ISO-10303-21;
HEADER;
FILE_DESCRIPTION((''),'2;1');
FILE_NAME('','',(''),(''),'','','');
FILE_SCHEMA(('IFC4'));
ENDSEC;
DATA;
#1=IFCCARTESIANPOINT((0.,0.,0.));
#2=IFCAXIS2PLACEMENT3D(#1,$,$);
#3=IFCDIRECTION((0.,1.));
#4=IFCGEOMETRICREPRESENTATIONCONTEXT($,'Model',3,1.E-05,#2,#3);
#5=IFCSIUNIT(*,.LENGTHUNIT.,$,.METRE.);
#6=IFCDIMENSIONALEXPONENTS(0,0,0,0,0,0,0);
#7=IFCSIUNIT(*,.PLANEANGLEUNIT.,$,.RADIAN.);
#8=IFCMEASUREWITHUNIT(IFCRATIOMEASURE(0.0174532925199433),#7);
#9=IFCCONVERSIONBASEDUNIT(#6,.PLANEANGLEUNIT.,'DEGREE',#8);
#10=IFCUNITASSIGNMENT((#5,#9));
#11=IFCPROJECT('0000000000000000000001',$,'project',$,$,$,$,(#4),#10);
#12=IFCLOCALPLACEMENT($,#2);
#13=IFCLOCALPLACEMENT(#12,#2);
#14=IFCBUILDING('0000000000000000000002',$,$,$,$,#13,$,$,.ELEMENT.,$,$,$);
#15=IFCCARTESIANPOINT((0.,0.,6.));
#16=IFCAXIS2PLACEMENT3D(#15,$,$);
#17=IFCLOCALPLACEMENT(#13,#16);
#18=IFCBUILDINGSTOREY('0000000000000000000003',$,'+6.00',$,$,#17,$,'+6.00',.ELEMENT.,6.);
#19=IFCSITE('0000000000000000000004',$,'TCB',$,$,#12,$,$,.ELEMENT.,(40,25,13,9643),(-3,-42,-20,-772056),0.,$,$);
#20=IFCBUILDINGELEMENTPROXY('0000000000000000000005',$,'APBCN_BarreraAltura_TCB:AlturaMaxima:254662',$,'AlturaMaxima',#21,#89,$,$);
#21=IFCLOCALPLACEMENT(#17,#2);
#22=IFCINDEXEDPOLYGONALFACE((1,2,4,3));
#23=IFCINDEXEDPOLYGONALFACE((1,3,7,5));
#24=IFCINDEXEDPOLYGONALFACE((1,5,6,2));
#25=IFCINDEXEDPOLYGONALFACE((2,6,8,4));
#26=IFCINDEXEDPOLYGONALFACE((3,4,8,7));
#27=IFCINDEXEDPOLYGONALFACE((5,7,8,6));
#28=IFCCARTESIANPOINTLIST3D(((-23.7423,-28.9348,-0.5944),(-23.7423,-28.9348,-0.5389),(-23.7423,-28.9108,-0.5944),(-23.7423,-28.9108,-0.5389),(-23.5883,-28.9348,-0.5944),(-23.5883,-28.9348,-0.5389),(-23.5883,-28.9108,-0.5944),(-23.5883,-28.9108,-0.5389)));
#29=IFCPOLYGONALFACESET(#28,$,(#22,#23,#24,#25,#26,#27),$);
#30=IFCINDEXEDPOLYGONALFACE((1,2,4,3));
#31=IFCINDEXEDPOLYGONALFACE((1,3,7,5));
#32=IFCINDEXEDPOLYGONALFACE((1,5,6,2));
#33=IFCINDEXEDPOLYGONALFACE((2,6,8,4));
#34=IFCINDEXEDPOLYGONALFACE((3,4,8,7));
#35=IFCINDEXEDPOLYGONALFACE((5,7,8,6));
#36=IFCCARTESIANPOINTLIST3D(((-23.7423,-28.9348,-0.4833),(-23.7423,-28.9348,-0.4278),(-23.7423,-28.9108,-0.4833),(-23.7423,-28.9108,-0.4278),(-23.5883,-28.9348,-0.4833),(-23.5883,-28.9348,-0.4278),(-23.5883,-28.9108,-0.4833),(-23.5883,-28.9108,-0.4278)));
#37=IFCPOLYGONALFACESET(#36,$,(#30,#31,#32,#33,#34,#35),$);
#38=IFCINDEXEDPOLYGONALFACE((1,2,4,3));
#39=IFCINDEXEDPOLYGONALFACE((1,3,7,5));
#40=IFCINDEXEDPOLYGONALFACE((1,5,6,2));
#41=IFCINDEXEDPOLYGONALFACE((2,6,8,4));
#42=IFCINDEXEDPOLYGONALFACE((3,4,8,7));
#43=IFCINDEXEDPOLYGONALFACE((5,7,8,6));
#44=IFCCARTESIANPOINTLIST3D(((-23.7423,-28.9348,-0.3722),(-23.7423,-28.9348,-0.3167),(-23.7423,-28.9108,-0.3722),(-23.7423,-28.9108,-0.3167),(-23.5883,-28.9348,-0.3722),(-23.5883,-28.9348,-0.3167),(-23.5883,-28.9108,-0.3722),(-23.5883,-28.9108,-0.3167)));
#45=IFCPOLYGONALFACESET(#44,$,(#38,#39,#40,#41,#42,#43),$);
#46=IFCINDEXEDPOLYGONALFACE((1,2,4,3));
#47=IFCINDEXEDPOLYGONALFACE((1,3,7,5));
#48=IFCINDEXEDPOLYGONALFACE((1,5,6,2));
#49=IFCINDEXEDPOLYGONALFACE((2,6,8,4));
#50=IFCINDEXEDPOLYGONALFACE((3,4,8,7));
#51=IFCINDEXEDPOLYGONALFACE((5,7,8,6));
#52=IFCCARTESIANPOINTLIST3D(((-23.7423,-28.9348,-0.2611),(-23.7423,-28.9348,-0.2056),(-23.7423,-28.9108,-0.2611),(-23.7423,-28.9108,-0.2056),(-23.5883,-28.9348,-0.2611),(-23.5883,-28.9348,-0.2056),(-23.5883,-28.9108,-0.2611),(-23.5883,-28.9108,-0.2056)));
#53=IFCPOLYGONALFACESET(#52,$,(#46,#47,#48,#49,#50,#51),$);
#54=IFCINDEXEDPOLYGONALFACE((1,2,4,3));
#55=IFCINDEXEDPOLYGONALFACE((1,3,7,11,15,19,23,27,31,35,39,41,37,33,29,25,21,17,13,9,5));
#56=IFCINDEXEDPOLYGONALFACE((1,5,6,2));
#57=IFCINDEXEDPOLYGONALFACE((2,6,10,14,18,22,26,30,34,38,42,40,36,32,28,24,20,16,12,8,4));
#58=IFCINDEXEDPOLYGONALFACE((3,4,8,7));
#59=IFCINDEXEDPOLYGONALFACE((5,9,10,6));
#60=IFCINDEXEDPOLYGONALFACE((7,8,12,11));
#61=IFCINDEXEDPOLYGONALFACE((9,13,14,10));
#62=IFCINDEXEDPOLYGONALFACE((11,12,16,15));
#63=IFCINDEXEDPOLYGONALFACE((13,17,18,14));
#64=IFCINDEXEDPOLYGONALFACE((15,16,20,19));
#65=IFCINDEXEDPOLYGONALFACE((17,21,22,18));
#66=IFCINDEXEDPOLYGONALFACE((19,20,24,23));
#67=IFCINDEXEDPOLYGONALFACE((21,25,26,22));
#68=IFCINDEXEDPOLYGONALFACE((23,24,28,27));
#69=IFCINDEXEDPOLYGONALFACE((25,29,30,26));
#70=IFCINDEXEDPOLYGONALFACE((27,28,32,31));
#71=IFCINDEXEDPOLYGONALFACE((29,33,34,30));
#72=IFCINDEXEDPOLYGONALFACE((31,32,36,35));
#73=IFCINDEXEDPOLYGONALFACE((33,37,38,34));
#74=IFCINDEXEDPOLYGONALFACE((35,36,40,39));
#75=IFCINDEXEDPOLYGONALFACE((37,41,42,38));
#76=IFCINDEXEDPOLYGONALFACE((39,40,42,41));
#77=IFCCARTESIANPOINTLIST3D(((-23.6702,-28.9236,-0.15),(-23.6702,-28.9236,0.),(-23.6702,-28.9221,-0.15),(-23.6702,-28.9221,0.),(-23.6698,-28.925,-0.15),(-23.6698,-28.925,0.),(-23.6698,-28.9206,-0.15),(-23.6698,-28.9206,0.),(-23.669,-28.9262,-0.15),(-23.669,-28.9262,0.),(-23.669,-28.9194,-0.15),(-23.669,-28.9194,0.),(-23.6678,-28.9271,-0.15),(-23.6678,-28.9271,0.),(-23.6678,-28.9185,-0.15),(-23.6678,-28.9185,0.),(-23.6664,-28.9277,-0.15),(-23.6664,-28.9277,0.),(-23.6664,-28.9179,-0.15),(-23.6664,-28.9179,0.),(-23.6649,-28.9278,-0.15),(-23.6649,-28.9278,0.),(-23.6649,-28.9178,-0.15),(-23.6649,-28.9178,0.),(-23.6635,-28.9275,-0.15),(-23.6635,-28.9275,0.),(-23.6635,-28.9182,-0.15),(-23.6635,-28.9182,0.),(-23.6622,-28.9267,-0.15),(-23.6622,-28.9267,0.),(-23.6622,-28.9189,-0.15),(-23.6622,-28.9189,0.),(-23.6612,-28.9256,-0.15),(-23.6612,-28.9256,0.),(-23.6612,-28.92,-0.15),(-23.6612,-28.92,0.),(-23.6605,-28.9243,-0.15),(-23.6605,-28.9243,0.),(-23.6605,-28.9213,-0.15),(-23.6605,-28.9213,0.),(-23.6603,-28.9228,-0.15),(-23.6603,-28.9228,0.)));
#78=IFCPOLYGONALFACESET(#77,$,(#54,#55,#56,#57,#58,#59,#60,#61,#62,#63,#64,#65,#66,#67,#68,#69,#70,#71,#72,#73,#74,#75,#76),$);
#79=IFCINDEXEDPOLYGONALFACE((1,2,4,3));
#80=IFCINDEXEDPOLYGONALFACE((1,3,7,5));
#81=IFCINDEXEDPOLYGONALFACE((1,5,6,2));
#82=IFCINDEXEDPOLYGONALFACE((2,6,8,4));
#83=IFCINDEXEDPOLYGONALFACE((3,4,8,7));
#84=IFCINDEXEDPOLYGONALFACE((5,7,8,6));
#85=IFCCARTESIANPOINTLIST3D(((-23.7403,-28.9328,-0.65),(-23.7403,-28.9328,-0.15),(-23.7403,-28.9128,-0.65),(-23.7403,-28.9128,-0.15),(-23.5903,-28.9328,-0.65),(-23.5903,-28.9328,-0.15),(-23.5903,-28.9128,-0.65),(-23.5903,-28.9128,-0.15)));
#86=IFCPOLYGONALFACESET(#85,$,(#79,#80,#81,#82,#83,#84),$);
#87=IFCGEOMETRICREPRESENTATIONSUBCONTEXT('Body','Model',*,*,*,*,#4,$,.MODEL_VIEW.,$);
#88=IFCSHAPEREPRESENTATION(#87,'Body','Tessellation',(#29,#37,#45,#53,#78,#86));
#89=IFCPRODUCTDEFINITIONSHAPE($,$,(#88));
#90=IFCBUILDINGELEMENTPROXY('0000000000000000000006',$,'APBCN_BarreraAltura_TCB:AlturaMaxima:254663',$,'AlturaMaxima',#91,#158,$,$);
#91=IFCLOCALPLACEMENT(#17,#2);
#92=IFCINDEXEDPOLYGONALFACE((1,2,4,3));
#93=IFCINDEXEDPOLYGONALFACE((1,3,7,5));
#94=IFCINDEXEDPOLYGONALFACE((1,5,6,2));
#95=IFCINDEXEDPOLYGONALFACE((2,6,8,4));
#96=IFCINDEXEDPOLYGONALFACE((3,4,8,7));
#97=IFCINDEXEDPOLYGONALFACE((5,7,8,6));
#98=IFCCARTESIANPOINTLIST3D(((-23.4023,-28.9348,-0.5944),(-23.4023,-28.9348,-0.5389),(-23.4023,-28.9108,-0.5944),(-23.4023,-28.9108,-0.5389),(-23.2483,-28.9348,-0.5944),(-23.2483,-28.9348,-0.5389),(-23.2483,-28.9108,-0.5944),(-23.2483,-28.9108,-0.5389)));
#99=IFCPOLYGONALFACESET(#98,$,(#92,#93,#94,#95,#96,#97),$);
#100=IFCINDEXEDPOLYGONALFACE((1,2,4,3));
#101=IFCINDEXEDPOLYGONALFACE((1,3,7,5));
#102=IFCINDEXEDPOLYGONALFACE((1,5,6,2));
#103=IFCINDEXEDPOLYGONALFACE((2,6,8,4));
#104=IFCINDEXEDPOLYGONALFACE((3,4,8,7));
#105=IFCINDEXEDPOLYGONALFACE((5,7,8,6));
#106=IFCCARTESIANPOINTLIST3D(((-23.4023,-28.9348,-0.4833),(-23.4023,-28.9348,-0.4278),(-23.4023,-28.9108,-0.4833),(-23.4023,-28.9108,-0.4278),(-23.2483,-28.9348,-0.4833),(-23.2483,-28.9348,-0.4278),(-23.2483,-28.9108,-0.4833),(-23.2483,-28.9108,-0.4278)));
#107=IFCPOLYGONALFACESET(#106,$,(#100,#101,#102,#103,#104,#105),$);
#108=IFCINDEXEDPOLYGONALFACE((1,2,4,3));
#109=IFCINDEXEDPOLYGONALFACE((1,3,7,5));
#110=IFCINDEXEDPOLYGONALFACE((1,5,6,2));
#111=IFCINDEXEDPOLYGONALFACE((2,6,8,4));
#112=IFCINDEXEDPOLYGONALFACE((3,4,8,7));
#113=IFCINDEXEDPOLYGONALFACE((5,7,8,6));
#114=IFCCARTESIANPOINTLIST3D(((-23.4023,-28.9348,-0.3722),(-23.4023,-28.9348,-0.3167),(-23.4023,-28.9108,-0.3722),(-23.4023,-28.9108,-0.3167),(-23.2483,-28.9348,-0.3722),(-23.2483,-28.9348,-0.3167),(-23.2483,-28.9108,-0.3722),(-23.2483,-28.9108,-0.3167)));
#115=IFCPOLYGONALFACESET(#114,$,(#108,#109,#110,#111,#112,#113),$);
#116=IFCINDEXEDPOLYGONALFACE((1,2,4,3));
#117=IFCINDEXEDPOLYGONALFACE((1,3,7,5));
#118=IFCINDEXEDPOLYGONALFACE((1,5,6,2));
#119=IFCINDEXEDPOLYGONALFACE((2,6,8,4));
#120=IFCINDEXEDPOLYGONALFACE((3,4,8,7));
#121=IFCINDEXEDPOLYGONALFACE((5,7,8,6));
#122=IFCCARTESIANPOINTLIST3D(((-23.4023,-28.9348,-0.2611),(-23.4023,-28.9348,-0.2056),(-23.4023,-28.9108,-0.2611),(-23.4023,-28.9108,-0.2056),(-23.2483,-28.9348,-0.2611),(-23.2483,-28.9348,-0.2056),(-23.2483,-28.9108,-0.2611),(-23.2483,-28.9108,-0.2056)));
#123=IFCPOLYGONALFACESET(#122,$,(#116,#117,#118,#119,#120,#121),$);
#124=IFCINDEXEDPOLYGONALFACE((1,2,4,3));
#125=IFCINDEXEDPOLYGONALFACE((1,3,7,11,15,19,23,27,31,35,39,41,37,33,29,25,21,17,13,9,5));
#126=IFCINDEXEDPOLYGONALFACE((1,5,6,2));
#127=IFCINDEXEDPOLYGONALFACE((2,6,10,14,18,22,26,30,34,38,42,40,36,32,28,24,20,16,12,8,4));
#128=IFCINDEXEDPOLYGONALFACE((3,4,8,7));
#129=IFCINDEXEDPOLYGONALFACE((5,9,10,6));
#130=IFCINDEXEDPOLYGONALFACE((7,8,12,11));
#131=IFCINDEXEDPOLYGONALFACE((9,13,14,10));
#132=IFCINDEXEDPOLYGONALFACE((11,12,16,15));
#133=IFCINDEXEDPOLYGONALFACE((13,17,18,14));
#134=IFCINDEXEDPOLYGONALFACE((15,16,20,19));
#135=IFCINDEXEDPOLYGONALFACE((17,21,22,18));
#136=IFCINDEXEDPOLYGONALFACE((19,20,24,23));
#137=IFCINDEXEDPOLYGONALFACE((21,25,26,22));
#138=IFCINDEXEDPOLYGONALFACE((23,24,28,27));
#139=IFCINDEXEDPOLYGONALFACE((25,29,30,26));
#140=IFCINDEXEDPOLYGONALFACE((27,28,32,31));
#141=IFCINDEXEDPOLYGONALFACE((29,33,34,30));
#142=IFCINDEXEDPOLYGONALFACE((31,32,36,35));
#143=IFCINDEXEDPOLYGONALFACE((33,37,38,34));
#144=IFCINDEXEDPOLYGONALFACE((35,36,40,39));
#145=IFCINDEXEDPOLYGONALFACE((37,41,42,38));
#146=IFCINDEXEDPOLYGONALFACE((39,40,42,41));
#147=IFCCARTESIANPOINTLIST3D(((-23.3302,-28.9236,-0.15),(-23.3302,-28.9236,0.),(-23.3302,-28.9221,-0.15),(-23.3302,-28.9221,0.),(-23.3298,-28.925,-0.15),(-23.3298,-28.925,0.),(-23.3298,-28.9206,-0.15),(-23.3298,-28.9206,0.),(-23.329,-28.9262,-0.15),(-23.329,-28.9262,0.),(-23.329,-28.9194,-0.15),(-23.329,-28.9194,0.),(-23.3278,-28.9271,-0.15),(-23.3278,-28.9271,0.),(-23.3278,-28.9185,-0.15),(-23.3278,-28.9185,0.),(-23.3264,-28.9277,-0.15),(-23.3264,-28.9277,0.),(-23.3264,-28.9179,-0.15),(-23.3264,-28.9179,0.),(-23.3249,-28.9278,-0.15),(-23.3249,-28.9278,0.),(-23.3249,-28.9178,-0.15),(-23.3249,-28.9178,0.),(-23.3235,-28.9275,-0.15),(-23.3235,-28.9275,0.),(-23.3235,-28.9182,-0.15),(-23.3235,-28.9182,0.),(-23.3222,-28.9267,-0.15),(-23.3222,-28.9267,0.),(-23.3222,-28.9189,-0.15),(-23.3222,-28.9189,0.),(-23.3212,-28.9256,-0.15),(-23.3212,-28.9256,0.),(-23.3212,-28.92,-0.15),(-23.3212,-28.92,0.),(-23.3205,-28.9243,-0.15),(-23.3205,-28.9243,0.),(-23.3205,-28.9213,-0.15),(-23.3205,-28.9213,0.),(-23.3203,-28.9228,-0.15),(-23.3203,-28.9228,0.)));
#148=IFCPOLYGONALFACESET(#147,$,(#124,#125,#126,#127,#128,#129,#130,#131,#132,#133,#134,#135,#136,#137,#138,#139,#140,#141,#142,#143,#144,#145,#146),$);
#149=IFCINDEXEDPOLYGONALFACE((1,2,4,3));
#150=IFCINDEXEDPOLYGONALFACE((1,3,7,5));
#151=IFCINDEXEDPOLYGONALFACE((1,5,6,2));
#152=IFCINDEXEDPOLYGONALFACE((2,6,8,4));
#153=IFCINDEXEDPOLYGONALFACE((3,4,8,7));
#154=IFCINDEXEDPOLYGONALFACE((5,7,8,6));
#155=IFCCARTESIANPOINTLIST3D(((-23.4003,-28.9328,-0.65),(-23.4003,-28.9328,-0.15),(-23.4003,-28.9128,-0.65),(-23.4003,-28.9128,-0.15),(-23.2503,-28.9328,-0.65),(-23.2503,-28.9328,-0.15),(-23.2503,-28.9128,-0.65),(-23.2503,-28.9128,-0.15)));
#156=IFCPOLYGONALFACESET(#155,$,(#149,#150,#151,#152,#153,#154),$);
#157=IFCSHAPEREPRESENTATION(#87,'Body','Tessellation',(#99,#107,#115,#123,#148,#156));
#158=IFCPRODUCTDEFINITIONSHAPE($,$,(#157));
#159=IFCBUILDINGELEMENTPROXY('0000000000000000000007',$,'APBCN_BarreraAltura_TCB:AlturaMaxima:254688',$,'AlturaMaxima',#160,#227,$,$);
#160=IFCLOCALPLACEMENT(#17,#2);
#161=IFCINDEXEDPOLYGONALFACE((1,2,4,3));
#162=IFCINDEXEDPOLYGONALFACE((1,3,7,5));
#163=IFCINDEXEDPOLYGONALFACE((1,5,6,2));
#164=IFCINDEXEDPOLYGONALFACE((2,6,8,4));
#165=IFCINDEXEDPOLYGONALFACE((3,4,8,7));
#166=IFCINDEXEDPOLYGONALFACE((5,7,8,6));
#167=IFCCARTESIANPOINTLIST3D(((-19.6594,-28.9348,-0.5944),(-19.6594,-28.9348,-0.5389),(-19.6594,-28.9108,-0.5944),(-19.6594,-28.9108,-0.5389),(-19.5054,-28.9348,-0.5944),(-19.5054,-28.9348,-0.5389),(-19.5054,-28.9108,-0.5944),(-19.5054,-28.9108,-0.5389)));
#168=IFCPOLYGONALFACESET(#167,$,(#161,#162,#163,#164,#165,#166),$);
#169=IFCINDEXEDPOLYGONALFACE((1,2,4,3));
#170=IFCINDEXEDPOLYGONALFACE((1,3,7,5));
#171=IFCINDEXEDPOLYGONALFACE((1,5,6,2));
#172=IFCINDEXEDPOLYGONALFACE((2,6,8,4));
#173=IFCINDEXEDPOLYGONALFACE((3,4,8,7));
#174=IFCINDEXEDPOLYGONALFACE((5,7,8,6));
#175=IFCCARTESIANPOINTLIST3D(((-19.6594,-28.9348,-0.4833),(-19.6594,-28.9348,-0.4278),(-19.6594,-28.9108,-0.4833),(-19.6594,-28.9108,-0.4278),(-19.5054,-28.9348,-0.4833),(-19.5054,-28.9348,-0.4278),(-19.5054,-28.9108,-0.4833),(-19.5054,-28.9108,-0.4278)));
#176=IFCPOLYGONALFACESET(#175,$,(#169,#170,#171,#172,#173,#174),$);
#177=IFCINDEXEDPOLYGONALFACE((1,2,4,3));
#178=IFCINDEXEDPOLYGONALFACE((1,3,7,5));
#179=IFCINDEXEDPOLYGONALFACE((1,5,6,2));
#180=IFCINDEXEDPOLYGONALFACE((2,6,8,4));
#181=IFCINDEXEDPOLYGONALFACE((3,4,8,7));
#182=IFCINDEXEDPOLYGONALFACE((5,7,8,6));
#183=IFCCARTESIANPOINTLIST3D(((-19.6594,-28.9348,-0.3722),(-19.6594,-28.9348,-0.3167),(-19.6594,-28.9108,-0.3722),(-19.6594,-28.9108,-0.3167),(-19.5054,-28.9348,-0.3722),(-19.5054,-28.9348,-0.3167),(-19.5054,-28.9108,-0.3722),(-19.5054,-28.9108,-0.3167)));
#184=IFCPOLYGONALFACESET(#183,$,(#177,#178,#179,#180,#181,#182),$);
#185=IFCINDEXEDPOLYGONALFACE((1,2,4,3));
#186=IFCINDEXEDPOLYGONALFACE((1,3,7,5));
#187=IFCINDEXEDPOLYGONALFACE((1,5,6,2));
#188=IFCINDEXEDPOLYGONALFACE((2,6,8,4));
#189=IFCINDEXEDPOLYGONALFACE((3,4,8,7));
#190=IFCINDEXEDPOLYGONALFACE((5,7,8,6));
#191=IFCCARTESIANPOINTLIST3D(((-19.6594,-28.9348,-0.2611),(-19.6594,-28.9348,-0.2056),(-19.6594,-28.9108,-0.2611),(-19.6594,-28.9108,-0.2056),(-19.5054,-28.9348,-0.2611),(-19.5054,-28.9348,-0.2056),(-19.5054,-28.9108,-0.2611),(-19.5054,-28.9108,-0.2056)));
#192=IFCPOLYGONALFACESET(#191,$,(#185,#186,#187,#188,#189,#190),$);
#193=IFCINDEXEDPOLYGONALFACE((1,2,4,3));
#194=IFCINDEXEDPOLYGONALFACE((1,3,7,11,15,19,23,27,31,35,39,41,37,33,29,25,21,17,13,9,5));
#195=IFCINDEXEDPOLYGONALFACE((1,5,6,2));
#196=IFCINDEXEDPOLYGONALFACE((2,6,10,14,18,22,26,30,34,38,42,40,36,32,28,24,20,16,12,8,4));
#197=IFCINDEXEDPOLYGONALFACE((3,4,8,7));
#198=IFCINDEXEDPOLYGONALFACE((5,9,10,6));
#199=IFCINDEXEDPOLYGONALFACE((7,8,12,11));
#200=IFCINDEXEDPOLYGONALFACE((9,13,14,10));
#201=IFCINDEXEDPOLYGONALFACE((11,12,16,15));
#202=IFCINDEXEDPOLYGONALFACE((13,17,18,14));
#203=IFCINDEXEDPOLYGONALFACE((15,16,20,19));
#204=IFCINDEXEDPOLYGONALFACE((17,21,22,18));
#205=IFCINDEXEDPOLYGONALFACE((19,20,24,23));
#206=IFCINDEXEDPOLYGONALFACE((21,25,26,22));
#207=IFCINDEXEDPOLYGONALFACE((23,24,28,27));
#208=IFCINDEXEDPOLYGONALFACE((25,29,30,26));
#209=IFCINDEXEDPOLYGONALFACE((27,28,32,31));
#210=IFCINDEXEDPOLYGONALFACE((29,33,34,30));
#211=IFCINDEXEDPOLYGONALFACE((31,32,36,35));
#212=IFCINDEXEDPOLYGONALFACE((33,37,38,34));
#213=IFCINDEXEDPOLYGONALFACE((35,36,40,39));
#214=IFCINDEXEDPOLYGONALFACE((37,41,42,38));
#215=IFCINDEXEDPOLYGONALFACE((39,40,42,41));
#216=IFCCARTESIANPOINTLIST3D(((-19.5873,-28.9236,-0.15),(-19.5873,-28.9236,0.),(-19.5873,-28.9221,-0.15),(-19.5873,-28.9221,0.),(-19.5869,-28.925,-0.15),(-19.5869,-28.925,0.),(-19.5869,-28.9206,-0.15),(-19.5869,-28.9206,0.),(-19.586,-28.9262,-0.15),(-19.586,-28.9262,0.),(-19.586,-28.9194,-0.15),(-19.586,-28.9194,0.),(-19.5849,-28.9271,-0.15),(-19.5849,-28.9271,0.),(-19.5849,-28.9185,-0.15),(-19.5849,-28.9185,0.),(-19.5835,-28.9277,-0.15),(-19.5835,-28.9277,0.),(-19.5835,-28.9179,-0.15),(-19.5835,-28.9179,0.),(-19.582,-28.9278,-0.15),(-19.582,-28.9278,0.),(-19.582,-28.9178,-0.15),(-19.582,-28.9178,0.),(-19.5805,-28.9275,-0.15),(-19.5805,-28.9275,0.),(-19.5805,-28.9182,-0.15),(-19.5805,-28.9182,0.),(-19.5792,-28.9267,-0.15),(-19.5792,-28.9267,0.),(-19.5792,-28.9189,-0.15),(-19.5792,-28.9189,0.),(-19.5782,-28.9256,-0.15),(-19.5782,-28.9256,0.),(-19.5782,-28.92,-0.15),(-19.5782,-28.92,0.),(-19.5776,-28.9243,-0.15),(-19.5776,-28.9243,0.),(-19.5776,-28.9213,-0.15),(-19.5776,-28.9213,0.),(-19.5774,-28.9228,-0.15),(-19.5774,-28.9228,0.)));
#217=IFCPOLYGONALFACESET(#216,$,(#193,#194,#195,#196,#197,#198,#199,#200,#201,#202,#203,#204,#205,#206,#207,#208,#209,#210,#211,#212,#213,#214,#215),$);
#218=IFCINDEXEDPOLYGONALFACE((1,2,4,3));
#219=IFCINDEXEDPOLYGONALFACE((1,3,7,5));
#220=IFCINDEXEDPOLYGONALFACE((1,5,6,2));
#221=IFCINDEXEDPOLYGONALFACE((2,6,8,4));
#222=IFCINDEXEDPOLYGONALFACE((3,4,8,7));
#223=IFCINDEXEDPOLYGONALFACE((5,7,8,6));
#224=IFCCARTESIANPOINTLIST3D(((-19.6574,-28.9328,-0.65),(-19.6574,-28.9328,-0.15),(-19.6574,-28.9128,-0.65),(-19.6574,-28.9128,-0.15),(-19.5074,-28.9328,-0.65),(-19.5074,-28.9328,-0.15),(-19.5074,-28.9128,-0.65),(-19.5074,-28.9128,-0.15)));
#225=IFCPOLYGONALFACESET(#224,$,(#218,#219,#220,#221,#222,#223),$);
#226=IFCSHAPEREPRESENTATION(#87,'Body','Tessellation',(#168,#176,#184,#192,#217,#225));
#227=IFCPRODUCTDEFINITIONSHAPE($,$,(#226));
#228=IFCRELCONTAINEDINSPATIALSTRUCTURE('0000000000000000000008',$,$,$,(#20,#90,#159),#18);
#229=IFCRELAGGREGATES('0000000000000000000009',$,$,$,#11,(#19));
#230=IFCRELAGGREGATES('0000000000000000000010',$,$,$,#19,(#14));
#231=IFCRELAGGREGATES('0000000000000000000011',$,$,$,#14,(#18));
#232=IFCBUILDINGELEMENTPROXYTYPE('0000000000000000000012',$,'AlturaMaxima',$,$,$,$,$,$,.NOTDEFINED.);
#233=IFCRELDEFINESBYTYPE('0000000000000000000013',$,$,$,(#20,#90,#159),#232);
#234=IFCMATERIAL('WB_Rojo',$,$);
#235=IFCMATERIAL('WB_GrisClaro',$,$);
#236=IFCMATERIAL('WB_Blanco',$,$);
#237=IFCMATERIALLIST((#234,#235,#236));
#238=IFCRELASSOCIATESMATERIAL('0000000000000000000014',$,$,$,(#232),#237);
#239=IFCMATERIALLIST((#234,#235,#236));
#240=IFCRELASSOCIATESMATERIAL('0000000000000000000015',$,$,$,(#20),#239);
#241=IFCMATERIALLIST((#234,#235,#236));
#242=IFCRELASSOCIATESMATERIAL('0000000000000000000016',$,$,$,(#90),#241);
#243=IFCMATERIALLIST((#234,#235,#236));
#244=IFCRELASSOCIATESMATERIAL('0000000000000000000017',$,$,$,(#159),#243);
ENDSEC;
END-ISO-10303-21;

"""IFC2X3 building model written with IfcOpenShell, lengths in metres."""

from ifc_helpers import new_model, entity, si_unit, converted_unit, direction, frame, frame_2d, origin, origin_2d_with_axis, place, context, subcontext, project, spatial, rectangle, circle, extrude, source, transform, mapped, material, material_list, type_object, type_shapes, element, save


model = new_model("IFC2X3")

# Units and contexts
model_context = context("Model", 3, precision=1e-05, world=origin(), true_north=direction((0.0, 1.0)))
body_context = subcontext(model_context, "Body", "Model", "MODEL_VIEW")
ifc_project = project(units=[si_unit("LENGTHUNIT", "METRE"), converted_unit("PLANEANGLEUNIT", "DEGREE", entity("IfcRatioMeasure", 0.0174532925199433), si_unit("PLANEANGLEUNIT", "RADIAN"), dimensions=[0, 0, 0, 0, 0, 0, 0])], contexts=[model_context])

# Site, building, storey
site_placement = place(None, origin())
site = spatial("IfcSite", under=ifc_project, at=site_placement, Name="TCB", CompositionType="ELEMENT", RefLatitude=(40, 25, 13, 9643), RefLongitude=(-3, -42, -20, -772056), RefElevation=0.0)
building_placement = place(site_placement, origin())
building = spatial("IfcBuilding", under=site, at=building_placement, CompositionType="ELEMENT")
storey_placement = place(building_placement, frame((0.0, 0.0, 6.0)))
storey = spatial("IfcBuildingStorey", under=building, at=storey_placement, Name="+6.00", LongName="+6.00", CompositionType="ELEMENT", Elevation=6.0)

# Building element proxies
ifc_material_1 = material(Name="WB_Rojo")
ifc_material_2 = material(Name="WB_GrisClaro")
ifc_material_3 = material(Name="WB_Blanco")
ifc_material_list_1 = material_list([ifc_material_1, ifc_material_2, ifc_material_3])
building_element_proxy_type = type_object("IfcBuildingElementProxyType", Name="AlturaMaxima", PredefinedType="NOTDEFINED", material=ifc_material_list_1)
shared_shape = source(origin(), body_context, "Body", "SweptSolid", [
    extrude(rectangle(XDim=0.154, YDim=0.024, at=frame_2d((0.0, 0.0), x_axis=(1.0, 0.0))), frame((0.0, 0.0, -0.5944), z_axis=(0.0, 0.0, 1.0), x_axis=(-1.0, 0.0, 0.0)), (0.0, 0.0, 1.0), 0.0556),
    extrude(rectangle(XDim=0.154, YDim=0.024, at=frame_2d((0.0, 0.0), x_axis=(1.0, 0.0))), frame((0.0, 0.0, -0.4833), z_axis=(0.0, 0.0, 1.0), x_axis=(-1.0, 0.0, 0.0)), (0.0, 0.0, 1.0), 0.0556),
    extrude(rectangle(XDim=0.154, YDim=0.024, at=frame_2d((0.0, 0.0), x_axis=(1.0, 0.0))), frame((0.0, 0.0, -0.3722), z_axis=(0.0, 0.0, 1.0), x_axis=(-1.0, 0.0, 0.0)), (0.0, 0.0, 1.0), 0.0556),
    extrude(rectangle(XDim=0.154, YDim=0.024, at=frame_2d((0.0, 0.0), x_axis=(1.0, 0.0))), frame((0.0, 0.0, -0.2611), z_axis=(0.0, 0.0, 1.0), x_axis=(-1.0, 0.0, 0.0)), (0.0, 0.0, 1.0), 0.0556),
    extrude(circle(Radius=0.005, at=frame_2d((0.0, 0.0), x_axis=(1.0, 0.0))), frame((0.0, 0.0, -0.15)), (0.0, 0.0, 1.0), 0.15),
    extrude(rectangle(XDim=0.02, YDim=0.15, at=origin_2d_with_axis()), frame((0.0, 0.0, -0.65), z_axis=(0.0, 0.0, 1.0), x_axis=(0.0, 1.0, 0.0)), (0.0, 0.0, 1.0), 0.5),
])
type_shapes(building_element_proxy_type, [shared_shape])
ifc_material_list_2 = material_list([ifc_material_1, ifc_material_2, ifc_material_3])
proxy_1_placement = place(storey_placement, frame((-23.6653, -28.9228, 0.0)))
element("IfcBuildingElementProxy", 1, at=proxy_1_placement, inside=storey, type_object=building_element_proxy_type, material=ifc_material_list_2, Name="APBCN_BarreraAltura_TCB:AlturaMaxima:254662", ObjectType="AlturaMaxima", context=body_context, shape_type="MappedRepresentation", body=[
    mapped(shared_shape, transform((0.0, 0.0, 0.0), scale=1.0)),
])
ifc_material_list_3 = material_list([ifc_material_1, ifc_material_2, ifc_material_3])
proxy_2_placement = place(storey_placement, frame((-23.3253, -28.9228, 0.0)))
element("IfcBuildingElementProxy", 2, at=proxy_2_placement, inside=storey, type_object=building_element_proxy_type, material=ifc_material_list_3, Name="APBCN_BarreraAltura_TCB:AlturaMaxima:254663", ObjectType="AlturaMaxima", context=body_context, shape_type="MappedRepresentation", body=[
    mapped(shared_shape, transform((0.0, 0.0, 0.0), scale=1.0)),
])
ifc_material_list_4 = material_list([ifc_material_1, ifc_material_2, ifc_material_3])
proxy_3_placement = place(storey_placement, frame((-19.5824, -28.9228, 0.0)))
element("IfcBuildingElementProxy", 3, at=proxy_3_placement, inside=storey, type_object=building_element_proxy_type, material=ifc_material_list_4, Name="APBCN_BarreraAltura_TCB:AlturaMaxima:254688", ObjectType="AlturaMaxima", context=body_context, shape_type="MappedRepresentation", body=[
    mapped(shared_shape, transform((0.0, 0.0, 0.0), scale=1.0)),
])

save(model, "model.ifc")
